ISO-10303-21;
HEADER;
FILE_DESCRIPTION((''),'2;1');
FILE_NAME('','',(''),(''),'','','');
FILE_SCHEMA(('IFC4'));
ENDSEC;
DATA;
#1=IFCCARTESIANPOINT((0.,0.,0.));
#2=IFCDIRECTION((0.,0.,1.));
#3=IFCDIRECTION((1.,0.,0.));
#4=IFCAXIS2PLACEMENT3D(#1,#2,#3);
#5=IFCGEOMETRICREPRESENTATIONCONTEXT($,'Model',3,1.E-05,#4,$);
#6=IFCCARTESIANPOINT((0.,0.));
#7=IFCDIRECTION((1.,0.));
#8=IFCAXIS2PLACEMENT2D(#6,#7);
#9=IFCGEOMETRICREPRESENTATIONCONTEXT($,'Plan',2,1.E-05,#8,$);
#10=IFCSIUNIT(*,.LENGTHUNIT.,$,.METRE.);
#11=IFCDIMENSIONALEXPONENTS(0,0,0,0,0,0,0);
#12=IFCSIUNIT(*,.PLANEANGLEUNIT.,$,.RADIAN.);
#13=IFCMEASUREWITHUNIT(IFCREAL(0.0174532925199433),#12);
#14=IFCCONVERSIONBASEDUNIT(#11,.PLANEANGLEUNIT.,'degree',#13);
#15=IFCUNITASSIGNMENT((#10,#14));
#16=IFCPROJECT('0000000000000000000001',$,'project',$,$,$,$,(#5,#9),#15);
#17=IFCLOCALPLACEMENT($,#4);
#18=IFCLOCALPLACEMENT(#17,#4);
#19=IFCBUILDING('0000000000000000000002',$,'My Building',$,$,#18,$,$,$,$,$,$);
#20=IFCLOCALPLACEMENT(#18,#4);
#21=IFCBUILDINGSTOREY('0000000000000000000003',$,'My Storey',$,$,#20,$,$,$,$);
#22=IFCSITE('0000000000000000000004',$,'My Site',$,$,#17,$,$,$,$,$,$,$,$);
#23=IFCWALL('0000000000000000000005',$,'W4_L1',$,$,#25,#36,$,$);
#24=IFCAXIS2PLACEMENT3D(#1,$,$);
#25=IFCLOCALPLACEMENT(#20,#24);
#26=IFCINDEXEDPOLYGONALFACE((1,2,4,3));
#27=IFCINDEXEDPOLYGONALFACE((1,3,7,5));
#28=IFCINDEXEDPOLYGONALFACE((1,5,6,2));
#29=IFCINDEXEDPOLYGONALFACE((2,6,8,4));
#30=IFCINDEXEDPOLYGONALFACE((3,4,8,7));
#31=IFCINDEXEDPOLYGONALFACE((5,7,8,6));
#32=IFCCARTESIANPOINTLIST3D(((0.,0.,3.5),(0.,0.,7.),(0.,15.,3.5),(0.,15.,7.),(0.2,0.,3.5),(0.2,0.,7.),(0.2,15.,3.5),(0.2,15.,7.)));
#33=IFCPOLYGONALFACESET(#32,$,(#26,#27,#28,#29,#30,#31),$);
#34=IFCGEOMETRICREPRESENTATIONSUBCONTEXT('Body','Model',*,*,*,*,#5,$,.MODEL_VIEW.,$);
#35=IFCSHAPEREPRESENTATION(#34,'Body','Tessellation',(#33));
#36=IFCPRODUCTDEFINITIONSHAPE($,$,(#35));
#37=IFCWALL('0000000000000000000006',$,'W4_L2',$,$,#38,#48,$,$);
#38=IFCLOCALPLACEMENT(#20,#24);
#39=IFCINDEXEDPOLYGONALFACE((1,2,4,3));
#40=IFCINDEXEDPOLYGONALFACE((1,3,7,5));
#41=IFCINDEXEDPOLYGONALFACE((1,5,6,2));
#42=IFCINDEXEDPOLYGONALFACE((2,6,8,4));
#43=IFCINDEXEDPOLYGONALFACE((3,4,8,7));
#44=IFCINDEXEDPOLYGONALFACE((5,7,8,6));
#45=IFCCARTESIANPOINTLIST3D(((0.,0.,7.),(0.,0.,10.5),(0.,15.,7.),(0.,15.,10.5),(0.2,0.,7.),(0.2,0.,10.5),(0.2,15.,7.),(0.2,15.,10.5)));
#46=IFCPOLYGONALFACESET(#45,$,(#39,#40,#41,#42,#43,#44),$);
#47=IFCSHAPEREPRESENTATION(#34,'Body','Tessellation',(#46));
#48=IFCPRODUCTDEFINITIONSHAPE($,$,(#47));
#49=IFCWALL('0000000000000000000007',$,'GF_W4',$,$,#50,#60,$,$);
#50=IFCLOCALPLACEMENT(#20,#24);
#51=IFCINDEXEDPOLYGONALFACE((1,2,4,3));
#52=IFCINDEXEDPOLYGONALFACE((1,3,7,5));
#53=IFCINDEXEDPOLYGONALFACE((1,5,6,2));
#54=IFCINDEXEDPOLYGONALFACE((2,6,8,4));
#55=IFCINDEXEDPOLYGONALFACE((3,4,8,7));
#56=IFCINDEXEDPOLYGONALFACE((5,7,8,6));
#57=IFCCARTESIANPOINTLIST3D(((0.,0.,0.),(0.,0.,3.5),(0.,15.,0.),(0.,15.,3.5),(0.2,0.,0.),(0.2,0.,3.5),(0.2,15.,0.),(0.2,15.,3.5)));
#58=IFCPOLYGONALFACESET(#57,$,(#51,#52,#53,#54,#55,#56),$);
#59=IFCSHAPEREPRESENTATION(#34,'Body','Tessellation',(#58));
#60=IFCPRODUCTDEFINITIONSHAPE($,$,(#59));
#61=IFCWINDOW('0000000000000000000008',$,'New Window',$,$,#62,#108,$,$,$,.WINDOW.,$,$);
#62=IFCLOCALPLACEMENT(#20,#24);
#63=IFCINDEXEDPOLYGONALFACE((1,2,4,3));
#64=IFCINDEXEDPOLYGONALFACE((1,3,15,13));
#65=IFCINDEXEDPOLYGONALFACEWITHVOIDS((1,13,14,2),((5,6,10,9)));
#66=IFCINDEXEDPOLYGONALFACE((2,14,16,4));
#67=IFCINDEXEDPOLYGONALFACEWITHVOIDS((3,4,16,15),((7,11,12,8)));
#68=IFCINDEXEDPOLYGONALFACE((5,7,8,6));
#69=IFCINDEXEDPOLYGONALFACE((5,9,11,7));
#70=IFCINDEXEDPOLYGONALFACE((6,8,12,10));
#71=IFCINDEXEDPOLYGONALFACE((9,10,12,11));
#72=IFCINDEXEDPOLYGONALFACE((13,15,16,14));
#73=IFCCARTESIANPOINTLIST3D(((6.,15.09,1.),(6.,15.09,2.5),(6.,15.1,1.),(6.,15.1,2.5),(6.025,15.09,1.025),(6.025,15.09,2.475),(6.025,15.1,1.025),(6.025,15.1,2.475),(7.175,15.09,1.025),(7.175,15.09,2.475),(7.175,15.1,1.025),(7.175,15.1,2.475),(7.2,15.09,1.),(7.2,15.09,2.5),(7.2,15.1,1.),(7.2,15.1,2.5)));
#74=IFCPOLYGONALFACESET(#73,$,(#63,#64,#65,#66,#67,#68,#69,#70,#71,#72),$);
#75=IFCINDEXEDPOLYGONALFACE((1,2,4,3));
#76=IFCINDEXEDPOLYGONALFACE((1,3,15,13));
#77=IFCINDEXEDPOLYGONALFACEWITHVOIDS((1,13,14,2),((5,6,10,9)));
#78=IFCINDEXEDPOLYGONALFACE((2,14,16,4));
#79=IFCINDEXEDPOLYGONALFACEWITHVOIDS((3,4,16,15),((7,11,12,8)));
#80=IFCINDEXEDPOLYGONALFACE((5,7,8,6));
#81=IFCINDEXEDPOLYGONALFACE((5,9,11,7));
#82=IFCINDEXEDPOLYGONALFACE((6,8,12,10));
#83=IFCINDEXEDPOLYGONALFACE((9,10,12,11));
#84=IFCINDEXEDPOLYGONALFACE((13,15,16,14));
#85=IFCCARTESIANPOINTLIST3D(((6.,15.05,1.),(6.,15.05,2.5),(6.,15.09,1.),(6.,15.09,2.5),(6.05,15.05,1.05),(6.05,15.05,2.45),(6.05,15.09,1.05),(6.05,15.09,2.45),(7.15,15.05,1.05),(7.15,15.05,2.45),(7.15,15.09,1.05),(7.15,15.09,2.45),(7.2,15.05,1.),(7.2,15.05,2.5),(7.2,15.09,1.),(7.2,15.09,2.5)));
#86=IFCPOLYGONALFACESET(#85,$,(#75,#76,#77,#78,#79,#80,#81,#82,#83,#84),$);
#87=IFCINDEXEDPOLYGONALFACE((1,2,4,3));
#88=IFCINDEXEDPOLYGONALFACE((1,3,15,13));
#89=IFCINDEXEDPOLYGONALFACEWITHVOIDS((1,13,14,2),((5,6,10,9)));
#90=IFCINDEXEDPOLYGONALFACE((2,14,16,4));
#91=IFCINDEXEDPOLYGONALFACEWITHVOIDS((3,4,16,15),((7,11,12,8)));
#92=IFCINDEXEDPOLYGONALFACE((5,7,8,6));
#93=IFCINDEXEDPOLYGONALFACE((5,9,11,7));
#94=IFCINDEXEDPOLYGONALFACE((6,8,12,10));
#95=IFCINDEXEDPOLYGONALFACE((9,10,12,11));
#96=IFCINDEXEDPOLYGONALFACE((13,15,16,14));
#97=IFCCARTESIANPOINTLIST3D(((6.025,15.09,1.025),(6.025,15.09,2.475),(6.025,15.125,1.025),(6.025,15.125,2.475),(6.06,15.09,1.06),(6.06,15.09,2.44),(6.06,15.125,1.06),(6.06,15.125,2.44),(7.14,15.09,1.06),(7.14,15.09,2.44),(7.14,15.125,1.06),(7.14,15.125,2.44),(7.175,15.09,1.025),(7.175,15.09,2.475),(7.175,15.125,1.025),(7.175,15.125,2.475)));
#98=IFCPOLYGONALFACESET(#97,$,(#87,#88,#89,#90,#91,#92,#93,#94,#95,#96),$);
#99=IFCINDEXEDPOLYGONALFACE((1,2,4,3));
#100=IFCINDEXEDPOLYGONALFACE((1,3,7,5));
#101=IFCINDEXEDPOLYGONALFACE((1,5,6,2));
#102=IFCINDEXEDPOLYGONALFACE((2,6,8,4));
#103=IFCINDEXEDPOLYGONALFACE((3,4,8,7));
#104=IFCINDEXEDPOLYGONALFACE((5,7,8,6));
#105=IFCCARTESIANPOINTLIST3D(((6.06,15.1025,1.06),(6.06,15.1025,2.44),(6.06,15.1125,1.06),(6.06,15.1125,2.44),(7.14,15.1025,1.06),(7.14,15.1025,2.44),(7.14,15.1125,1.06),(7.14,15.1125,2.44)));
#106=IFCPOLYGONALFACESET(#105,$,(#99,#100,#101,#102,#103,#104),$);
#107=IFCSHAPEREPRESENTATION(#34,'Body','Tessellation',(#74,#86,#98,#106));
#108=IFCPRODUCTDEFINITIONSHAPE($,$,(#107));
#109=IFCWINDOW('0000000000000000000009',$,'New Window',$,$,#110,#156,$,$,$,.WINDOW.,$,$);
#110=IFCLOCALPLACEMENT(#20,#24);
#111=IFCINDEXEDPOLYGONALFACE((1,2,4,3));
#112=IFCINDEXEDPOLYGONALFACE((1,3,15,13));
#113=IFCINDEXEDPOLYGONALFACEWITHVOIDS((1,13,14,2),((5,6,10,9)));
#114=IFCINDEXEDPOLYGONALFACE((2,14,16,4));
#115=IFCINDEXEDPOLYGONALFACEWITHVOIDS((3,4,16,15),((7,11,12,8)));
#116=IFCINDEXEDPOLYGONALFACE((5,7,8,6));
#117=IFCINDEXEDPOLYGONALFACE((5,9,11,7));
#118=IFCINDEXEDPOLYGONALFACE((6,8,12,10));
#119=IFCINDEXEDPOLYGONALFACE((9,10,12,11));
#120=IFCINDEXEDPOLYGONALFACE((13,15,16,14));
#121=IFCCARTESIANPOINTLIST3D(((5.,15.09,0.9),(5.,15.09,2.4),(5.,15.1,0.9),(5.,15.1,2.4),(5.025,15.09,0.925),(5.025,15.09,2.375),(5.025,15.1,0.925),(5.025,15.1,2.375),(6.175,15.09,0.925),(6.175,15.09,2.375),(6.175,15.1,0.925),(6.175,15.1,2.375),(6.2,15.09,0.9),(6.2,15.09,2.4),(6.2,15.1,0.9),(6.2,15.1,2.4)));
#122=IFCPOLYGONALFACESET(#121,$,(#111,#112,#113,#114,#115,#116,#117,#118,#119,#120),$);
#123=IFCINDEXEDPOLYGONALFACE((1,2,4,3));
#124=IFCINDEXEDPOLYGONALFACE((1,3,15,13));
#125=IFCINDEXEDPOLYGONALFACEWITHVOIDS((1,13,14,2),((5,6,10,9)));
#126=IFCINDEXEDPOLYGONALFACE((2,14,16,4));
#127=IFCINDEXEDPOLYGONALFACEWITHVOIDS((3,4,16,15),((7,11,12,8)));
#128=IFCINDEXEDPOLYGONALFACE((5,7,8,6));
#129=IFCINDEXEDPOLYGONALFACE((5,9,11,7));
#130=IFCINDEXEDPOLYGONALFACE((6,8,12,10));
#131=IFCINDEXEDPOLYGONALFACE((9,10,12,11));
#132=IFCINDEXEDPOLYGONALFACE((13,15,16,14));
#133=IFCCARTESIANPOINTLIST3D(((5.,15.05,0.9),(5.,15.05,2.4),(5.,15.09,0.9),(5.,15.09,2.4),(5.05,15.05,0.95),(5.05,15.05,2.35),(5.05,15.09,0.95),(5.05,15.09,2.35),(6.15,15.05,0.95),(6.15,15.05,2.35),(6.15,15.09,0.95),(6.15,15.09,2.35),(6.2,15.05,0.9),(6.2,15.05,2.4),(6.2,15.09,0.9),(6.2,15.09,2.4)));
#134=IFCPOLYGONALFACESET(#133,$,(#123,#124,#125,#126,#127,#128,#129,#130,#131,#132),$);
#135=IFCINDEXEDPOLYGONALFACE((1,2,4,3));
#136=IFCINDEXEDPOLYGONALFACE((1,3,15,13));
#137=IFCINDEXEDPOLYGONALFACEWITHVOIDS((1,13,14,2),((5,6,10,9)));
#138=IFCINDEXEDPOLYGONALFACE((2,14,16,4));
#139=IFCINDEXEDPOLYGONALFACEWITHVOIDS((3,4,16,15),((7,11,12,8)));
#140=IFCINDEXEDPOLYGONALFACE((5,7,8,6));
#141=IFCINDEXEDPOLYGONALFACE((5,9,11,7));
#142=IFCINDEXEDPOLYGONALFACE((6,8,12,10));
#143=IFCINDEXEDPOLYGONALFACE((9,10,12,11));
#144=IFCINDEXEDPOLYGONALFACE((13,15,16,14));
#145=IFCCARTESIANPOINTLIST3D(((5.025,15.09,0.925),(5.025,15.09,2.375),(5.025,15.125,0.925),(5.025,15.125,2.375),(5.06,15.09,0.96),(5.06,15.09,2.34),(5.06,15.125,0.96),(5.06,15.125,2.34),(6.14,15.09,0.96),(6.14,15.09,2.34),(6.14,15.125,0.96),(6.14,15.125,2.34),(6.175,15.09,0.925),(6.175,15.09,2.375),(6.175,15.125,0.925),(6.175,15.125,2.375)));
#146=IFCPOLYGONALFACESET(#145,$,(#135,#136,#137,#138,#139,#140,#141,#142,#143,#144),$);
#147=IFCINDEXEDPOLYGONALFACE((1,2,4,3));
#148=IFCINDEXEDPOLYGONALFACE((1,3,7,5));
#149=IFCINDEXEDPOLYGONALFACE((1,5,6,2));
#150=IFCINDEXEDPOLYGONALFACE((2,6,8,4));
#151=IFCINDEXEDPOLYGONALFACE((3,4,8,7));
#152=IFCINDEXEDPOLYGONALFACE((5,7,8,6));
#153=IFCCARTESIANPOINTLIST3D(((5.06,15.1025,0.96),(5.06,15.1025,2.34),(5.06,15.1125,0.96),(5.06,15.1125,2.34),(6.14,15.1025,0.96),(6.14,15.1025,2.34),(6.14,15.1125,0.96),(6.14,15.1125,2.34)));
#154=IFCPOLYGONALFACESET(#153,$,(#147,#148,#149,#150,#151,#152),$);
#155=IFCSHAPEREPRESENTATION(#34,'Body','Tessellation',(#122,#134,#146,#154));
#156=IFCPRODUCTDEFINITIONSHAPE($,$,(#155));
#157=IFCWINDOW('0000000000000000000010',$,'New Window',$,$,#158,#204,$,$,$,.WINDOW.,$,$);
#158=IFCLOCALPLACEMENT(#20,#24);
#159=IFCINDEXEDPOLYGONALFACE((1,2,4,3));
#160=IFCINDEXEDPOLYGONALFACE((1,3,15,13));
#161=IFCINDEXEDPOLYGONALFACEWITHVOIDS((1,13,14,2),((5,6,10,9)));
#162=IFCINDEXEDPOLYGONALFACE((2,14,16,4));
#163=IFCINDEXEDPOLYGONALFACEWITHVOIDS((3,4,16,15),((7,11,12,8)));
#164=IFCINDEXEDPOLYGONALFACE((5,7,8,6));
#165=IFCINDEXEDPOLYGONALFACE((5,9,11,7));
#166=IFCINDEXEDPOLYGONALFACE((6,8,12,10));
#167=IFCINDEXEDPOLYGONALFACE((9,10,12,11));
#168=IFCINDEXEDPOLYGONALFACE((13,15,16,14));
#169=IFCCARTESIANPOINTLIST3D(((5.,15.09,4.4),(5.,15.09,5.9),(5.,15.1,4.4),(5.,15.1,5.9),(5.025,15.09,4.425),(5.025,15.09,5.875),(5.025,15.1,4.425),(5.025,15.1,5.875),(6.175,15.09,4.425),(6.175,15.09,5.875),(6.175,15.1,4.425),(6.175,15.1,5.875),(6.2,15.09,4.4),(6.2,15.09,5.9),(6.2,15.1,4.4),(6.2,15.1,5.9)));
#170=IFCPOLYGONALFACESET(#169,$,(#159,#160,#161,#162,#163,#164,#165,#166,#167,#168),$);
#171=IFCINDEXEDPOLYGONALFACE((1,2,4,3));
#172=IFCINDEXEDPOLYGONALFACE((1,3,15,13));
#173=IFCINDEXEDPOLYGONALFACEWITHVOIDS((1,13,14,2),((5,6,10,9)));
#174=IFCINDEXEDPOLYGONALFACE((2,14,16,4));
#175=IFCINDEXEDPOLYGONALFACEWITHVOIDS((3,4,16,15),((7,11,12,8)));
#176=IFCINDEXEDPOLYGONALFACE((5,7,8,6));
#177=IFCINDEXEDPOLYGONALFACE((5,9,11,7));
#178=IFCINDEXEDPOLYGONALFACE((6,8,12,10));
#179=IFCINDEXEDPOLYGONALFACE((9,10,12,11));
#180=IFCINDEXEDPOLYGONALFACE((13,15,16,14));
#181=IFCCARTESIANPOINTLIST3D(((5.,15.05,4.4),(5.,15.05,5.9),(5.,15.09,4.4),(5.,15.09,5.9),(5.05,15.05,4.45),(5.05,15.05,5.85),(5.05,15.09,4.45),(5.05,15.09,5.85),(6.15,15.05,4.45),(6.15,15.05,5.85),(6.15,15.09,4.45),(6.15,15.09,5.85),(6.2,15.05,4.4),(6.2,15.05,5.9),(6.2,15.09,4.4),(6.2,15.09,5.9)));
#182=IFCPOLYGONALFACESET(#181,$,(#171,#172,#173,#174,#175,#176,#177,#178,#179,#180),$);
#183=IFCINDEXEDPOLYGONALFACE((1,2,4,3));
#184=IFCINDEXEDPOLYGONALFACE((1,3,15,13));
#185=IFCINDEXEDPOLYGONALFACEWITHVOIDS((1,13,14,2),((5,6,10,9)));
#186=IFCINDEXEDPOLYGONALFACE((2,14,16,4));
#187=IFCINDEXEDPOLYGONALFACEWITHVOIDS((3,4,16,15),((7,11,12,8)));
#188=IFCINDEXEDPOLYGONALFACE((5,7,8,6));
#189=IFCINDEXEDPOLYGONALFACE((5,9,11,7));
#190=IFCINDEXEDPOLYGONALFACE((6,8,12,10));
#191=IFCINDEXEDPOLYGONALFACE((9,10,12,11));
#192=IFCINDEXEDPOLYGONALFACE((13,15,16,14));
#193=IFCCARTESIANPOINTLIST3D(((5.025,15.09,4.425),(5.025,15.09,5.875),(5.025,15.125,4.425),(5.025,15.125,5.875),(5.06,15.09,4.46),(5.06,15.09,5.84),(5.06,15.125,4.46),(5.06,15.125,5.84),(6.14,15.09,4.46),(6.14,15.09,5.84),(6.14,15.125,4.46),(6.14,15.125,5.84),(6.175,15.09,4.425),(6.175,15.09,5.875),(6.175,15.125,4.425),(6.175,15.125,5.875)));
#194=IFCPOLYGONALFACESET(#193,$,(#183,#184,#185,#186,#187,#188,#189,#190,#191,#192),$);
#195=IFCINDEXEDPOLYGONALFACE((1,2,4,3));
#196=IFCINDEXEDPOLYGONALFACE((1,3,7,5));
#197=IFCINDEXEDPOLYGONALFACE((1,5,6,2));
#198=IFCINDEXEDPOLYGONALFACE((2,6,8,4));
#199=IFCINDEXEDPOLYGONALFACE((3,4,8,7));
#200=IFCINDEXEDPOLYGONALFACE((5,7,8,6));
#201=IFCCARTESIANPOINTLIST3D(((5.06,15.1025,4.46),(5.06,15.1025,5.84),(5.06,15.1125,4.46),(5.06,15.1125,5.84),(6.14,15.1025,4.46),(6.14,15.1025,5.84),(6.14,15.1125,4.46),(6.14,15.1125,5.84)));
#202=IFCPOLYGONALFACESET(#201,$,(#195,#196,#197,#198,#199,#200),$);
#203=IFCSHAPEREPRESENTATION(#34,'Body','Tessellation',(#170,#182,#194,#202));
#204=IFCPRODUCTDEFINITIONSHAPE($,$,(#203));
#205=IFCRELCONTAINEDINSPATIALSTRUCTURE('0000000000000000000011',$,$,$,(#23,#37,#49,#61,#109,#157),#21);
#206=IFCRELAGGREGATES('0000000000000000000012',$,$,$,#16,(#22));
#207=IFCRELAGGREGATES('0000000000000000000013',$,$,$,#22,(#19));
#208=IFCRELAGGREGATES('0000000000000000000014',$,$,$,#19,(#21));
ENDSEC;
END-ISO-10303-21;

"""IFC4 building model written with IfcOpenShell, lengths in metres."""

from ifc_helpers import new_model, entity, si_unit, converted_unit, frame, origin_with_axes, origin_2d_with_axis, place, context, subcontext, project, spatial, line, indexed_curve, outline, extrude, element, save


model = new_model("IFC4")

# Units and contexts
model_context = context("Model", 3, precision=1e-05, world=origin_with_axes())
plan_context = context("Plan", 2, precision=1e-05, world=origin_2d_with_axis())
body_context = subcontext(model_context, "Body", "Model", "MODEL_VIEW")
ifc_project = project(units=[si_unit("LENGTHUNIT", "METRE"), converted_unit("PLANEANGLEUNIT", "degree", entity("IfcReal", 0.0174532925199433), si_unit("PLANEANGLEUNIT", "RADIAN"), dimensions=[0, 0, 0, 0, 0, 0, 0])], contexts=[model_context, plan_context])

# Site, building, storey
site_placement = place(None, origin_with_axes())
site = spatial("IfcSite", under=ifc_project, at=site_placement, Name="My Site")
building_placement = place(site_placement, origin_with_axes())
building = spatial("IfcBuilding", under=site, at=building_placement, Name="My Building")
storey_placement = place(building_placement, origin_with_axes())
storey = spatial("IfcBuildingStorey", under=building, at=storey_placement, Name="My Storey")

# Walls
for number, where, z_axis, x_axis, name in (
    (1, (0.0, 15.0, 3.5), (0.0, 0.0, 1.0), (0.0, -1.0, 0.0), "W4_L1"),
    (2, (0.0, 15.0, 7.0), (0.0, 0.0, 1.0), (0.0, -1.0, 0.0), "W4_L2"),
    (3, (0.0, 15.0, 0.0), (0.0, 0.0, 1.0), (0.0, -1.0, 0.0), "GF_W4"),
):
    element("IfcWall", number, at=place(storey_placement, frame(where, z_axis=z_axis, x_axis=x_axis)), inside=storey, Name=name, context=body_context, shape_type="SweptSolid", body=[
        extrude(outline(indexed_curve([(0.0, 0.0), (0.0, 0.2), (15.0, 0.2), (15.0, 0.0), (0.0, 0.0)], self_intersect=False)), origin_with_axes(), (0.0, 0.0, 1.0), 3.5),
    ])

# Window
window_placement = place(storey_placement, frame((6.0, 15.0, 1.0), z_axis=(0.0, 0.0, 1.0), x_axis=(1.0, 0.0, 0.0)))
element("IfcWindow", 4, at=window_placement, inside=storey, Name="New Window", PredefinedType="WINDOW", context=body_context, shape_type="SweptSolid", body=[
    extrude(outline(indexed_curve([(0.0, 0.0), (1.2, 0.0), (1.2, 1.5), (0.0, 1.5)], segments=[line(1, 2, 3, 4, 1)]), holes=[indexed_curve([(0.025, 0.025), (1.175, 0.025), (1.175, 1.475), (0.025, 1.475)], segments=[line(1, 2, 3, 4, 1)])]), frame((0.0, 0.09, 0.0), z_axis=(0.0, -1.0, 0.0), x_axis=(1.0, 0.0, 0.0)), (0.0, 0.0, -1.0), 0.01),
    extrude(outline(indexed_curve([(0.0, 0.0), (1.2, 0.0), (1.2, 1.5), (0.0, 1.5)], segments=[line(1, 2, 3, 4, 1)]), holes=[indexed_curve([(0.05, 0.05), (1.15, 0.05), (1.15, 1.45), (0.05, 1.45)], segments=[line(1, 2, 3, 4, 1)])]), frame((0.0, 0.05, 0.0), z_axis=(0.0, -1.0, 0.0), x_axis=(1.0, 0.0, 0.0)), (0.0, 0.0, -1.0), 0.04),
    extrude(outline(indexed_curve([(0.0, 0.0), (1.15, 0.0), (1.15, 1.45), (0.0, 1.45)], segments=[line(1, 2, 3, 4, 1)]), holes=[indexed_curve([(0.035, 0.035), (1.115, 0.035), (1.115, 1.415), (0.035, 1.415)], segments=[line(1, 2, 3, 4, 1)])]), frame((0.025, 0.09, 0.025), z_axis=(0.0, -1.0, 0.0), x_axis=(1.0, 0.0, 0.0)), (0.0, 0.0, -1.0), 0.035),
    extrude(outline(indexed_curve([(0.035, 0.035), (1.115, 0.035), (1.115, 1.415), (0.035, 1.415)], segments=[line(1, 2, 3, 4, 1)])), frame((0.025, 0.1025, 0.025), z_axis=(0.0, -1.0, 0.0), x_axis=(1.0, 0.0, 0.0)), (0.0, 0.0, -1.0), 0.01),
])

# Windows
for number, where, z_axis, x_axis, name in (
    (5, (5.0, 15.0, 0.9), (0.0, 0.0, 1.0), (1.0, 0.0, 0.0), "New Window"),
    (6, (5.0, 15.0, 4.4), (0.0, 0.0, 1.0), (1.0, 0.0, 0.0), "New Window"),
):
    element("IfcWindow", number, at=place(storey_placement, frame(where, z_axis=z_axis, x_axis=x_axis)), inside=storey, Name=name, PredefinedType="WINDOW", context=body_context, shape_type="SweptSolid", body=[
        extrude(outline(indexed_curve([(0.0, 0.0), (1.2, 0.0), (1.2, 1.5), (0.0, 1.5)], segments=[line(1, 2, 3, 4, 1)]), holes=[indexed_curve([(0.025, 0.025), (1.175, 0.025), (1.175, 1.475), (0.025, 1.475)], segments=[line(1, 2, 3, 4, 1)])]), frame((0.0, 0.09, 0.0), z_axis=(0.0, -1.0, 0.0), x_axis=(1.0, 0.0, 0.0)), (0.0, 0.0, -1.0), 0.01),
        extrude(outline(indexed_curve([(0.0, 0.0), (1.2, 0.0), (1.2, 1.5), (0.0, 1.5)], segments=[line(1, 2, 3, 4, 1)]), holes=[indexed_curve([(0.05, 0.05), (1.15, 0.05), (1.15, 1.45), (0.05, 1.45)], segments=[line(1, 2, 3, 4, 1)])]), frame((0.0, 0.05, 0.0), z_axis=(0.0, -1.0, 0.0), x_axis=(1.0, 0.0, 0.0)), (0.0, 0.0, -1.0), 0.04),
        extrude(outline(indexed_curve([(0.0, 0.0), (1.15, 0.0), (1.15, 1.45), (0.0, 1.45)], segments=[line(1, 2, 3, 4, 1)]), holes=[indexed_curve([(0.035, 0.035), (1.115, 0.035), (1.115, 1.415), (0.035, 1.415)], segments=[line(1, 2, 3, 4, 1)])]), frame((0.025, 0.09, 0.025), z_axis=(0.0, -1.0, 0.0), x_axis=(1.0, 0.0, 0.0)), (0.0, 0.0, -1.0), 0.035),
        extrude(outline(indexed_curve([(0.035, 0.035), (1.115, 0.035), (1.115, 1.415), (0.035, 1.415)], segments=[line(1, 2, 3, 4, 1)])), frame((0.025, 0.1025, 0.025), z_axis=(0.0, -1.0, 0.0), x_axis=(1.0, 0.0, 0.0)), (0.0, 0.0, -1.0), 0.01),
    ])

save(model, "model.ifc")
